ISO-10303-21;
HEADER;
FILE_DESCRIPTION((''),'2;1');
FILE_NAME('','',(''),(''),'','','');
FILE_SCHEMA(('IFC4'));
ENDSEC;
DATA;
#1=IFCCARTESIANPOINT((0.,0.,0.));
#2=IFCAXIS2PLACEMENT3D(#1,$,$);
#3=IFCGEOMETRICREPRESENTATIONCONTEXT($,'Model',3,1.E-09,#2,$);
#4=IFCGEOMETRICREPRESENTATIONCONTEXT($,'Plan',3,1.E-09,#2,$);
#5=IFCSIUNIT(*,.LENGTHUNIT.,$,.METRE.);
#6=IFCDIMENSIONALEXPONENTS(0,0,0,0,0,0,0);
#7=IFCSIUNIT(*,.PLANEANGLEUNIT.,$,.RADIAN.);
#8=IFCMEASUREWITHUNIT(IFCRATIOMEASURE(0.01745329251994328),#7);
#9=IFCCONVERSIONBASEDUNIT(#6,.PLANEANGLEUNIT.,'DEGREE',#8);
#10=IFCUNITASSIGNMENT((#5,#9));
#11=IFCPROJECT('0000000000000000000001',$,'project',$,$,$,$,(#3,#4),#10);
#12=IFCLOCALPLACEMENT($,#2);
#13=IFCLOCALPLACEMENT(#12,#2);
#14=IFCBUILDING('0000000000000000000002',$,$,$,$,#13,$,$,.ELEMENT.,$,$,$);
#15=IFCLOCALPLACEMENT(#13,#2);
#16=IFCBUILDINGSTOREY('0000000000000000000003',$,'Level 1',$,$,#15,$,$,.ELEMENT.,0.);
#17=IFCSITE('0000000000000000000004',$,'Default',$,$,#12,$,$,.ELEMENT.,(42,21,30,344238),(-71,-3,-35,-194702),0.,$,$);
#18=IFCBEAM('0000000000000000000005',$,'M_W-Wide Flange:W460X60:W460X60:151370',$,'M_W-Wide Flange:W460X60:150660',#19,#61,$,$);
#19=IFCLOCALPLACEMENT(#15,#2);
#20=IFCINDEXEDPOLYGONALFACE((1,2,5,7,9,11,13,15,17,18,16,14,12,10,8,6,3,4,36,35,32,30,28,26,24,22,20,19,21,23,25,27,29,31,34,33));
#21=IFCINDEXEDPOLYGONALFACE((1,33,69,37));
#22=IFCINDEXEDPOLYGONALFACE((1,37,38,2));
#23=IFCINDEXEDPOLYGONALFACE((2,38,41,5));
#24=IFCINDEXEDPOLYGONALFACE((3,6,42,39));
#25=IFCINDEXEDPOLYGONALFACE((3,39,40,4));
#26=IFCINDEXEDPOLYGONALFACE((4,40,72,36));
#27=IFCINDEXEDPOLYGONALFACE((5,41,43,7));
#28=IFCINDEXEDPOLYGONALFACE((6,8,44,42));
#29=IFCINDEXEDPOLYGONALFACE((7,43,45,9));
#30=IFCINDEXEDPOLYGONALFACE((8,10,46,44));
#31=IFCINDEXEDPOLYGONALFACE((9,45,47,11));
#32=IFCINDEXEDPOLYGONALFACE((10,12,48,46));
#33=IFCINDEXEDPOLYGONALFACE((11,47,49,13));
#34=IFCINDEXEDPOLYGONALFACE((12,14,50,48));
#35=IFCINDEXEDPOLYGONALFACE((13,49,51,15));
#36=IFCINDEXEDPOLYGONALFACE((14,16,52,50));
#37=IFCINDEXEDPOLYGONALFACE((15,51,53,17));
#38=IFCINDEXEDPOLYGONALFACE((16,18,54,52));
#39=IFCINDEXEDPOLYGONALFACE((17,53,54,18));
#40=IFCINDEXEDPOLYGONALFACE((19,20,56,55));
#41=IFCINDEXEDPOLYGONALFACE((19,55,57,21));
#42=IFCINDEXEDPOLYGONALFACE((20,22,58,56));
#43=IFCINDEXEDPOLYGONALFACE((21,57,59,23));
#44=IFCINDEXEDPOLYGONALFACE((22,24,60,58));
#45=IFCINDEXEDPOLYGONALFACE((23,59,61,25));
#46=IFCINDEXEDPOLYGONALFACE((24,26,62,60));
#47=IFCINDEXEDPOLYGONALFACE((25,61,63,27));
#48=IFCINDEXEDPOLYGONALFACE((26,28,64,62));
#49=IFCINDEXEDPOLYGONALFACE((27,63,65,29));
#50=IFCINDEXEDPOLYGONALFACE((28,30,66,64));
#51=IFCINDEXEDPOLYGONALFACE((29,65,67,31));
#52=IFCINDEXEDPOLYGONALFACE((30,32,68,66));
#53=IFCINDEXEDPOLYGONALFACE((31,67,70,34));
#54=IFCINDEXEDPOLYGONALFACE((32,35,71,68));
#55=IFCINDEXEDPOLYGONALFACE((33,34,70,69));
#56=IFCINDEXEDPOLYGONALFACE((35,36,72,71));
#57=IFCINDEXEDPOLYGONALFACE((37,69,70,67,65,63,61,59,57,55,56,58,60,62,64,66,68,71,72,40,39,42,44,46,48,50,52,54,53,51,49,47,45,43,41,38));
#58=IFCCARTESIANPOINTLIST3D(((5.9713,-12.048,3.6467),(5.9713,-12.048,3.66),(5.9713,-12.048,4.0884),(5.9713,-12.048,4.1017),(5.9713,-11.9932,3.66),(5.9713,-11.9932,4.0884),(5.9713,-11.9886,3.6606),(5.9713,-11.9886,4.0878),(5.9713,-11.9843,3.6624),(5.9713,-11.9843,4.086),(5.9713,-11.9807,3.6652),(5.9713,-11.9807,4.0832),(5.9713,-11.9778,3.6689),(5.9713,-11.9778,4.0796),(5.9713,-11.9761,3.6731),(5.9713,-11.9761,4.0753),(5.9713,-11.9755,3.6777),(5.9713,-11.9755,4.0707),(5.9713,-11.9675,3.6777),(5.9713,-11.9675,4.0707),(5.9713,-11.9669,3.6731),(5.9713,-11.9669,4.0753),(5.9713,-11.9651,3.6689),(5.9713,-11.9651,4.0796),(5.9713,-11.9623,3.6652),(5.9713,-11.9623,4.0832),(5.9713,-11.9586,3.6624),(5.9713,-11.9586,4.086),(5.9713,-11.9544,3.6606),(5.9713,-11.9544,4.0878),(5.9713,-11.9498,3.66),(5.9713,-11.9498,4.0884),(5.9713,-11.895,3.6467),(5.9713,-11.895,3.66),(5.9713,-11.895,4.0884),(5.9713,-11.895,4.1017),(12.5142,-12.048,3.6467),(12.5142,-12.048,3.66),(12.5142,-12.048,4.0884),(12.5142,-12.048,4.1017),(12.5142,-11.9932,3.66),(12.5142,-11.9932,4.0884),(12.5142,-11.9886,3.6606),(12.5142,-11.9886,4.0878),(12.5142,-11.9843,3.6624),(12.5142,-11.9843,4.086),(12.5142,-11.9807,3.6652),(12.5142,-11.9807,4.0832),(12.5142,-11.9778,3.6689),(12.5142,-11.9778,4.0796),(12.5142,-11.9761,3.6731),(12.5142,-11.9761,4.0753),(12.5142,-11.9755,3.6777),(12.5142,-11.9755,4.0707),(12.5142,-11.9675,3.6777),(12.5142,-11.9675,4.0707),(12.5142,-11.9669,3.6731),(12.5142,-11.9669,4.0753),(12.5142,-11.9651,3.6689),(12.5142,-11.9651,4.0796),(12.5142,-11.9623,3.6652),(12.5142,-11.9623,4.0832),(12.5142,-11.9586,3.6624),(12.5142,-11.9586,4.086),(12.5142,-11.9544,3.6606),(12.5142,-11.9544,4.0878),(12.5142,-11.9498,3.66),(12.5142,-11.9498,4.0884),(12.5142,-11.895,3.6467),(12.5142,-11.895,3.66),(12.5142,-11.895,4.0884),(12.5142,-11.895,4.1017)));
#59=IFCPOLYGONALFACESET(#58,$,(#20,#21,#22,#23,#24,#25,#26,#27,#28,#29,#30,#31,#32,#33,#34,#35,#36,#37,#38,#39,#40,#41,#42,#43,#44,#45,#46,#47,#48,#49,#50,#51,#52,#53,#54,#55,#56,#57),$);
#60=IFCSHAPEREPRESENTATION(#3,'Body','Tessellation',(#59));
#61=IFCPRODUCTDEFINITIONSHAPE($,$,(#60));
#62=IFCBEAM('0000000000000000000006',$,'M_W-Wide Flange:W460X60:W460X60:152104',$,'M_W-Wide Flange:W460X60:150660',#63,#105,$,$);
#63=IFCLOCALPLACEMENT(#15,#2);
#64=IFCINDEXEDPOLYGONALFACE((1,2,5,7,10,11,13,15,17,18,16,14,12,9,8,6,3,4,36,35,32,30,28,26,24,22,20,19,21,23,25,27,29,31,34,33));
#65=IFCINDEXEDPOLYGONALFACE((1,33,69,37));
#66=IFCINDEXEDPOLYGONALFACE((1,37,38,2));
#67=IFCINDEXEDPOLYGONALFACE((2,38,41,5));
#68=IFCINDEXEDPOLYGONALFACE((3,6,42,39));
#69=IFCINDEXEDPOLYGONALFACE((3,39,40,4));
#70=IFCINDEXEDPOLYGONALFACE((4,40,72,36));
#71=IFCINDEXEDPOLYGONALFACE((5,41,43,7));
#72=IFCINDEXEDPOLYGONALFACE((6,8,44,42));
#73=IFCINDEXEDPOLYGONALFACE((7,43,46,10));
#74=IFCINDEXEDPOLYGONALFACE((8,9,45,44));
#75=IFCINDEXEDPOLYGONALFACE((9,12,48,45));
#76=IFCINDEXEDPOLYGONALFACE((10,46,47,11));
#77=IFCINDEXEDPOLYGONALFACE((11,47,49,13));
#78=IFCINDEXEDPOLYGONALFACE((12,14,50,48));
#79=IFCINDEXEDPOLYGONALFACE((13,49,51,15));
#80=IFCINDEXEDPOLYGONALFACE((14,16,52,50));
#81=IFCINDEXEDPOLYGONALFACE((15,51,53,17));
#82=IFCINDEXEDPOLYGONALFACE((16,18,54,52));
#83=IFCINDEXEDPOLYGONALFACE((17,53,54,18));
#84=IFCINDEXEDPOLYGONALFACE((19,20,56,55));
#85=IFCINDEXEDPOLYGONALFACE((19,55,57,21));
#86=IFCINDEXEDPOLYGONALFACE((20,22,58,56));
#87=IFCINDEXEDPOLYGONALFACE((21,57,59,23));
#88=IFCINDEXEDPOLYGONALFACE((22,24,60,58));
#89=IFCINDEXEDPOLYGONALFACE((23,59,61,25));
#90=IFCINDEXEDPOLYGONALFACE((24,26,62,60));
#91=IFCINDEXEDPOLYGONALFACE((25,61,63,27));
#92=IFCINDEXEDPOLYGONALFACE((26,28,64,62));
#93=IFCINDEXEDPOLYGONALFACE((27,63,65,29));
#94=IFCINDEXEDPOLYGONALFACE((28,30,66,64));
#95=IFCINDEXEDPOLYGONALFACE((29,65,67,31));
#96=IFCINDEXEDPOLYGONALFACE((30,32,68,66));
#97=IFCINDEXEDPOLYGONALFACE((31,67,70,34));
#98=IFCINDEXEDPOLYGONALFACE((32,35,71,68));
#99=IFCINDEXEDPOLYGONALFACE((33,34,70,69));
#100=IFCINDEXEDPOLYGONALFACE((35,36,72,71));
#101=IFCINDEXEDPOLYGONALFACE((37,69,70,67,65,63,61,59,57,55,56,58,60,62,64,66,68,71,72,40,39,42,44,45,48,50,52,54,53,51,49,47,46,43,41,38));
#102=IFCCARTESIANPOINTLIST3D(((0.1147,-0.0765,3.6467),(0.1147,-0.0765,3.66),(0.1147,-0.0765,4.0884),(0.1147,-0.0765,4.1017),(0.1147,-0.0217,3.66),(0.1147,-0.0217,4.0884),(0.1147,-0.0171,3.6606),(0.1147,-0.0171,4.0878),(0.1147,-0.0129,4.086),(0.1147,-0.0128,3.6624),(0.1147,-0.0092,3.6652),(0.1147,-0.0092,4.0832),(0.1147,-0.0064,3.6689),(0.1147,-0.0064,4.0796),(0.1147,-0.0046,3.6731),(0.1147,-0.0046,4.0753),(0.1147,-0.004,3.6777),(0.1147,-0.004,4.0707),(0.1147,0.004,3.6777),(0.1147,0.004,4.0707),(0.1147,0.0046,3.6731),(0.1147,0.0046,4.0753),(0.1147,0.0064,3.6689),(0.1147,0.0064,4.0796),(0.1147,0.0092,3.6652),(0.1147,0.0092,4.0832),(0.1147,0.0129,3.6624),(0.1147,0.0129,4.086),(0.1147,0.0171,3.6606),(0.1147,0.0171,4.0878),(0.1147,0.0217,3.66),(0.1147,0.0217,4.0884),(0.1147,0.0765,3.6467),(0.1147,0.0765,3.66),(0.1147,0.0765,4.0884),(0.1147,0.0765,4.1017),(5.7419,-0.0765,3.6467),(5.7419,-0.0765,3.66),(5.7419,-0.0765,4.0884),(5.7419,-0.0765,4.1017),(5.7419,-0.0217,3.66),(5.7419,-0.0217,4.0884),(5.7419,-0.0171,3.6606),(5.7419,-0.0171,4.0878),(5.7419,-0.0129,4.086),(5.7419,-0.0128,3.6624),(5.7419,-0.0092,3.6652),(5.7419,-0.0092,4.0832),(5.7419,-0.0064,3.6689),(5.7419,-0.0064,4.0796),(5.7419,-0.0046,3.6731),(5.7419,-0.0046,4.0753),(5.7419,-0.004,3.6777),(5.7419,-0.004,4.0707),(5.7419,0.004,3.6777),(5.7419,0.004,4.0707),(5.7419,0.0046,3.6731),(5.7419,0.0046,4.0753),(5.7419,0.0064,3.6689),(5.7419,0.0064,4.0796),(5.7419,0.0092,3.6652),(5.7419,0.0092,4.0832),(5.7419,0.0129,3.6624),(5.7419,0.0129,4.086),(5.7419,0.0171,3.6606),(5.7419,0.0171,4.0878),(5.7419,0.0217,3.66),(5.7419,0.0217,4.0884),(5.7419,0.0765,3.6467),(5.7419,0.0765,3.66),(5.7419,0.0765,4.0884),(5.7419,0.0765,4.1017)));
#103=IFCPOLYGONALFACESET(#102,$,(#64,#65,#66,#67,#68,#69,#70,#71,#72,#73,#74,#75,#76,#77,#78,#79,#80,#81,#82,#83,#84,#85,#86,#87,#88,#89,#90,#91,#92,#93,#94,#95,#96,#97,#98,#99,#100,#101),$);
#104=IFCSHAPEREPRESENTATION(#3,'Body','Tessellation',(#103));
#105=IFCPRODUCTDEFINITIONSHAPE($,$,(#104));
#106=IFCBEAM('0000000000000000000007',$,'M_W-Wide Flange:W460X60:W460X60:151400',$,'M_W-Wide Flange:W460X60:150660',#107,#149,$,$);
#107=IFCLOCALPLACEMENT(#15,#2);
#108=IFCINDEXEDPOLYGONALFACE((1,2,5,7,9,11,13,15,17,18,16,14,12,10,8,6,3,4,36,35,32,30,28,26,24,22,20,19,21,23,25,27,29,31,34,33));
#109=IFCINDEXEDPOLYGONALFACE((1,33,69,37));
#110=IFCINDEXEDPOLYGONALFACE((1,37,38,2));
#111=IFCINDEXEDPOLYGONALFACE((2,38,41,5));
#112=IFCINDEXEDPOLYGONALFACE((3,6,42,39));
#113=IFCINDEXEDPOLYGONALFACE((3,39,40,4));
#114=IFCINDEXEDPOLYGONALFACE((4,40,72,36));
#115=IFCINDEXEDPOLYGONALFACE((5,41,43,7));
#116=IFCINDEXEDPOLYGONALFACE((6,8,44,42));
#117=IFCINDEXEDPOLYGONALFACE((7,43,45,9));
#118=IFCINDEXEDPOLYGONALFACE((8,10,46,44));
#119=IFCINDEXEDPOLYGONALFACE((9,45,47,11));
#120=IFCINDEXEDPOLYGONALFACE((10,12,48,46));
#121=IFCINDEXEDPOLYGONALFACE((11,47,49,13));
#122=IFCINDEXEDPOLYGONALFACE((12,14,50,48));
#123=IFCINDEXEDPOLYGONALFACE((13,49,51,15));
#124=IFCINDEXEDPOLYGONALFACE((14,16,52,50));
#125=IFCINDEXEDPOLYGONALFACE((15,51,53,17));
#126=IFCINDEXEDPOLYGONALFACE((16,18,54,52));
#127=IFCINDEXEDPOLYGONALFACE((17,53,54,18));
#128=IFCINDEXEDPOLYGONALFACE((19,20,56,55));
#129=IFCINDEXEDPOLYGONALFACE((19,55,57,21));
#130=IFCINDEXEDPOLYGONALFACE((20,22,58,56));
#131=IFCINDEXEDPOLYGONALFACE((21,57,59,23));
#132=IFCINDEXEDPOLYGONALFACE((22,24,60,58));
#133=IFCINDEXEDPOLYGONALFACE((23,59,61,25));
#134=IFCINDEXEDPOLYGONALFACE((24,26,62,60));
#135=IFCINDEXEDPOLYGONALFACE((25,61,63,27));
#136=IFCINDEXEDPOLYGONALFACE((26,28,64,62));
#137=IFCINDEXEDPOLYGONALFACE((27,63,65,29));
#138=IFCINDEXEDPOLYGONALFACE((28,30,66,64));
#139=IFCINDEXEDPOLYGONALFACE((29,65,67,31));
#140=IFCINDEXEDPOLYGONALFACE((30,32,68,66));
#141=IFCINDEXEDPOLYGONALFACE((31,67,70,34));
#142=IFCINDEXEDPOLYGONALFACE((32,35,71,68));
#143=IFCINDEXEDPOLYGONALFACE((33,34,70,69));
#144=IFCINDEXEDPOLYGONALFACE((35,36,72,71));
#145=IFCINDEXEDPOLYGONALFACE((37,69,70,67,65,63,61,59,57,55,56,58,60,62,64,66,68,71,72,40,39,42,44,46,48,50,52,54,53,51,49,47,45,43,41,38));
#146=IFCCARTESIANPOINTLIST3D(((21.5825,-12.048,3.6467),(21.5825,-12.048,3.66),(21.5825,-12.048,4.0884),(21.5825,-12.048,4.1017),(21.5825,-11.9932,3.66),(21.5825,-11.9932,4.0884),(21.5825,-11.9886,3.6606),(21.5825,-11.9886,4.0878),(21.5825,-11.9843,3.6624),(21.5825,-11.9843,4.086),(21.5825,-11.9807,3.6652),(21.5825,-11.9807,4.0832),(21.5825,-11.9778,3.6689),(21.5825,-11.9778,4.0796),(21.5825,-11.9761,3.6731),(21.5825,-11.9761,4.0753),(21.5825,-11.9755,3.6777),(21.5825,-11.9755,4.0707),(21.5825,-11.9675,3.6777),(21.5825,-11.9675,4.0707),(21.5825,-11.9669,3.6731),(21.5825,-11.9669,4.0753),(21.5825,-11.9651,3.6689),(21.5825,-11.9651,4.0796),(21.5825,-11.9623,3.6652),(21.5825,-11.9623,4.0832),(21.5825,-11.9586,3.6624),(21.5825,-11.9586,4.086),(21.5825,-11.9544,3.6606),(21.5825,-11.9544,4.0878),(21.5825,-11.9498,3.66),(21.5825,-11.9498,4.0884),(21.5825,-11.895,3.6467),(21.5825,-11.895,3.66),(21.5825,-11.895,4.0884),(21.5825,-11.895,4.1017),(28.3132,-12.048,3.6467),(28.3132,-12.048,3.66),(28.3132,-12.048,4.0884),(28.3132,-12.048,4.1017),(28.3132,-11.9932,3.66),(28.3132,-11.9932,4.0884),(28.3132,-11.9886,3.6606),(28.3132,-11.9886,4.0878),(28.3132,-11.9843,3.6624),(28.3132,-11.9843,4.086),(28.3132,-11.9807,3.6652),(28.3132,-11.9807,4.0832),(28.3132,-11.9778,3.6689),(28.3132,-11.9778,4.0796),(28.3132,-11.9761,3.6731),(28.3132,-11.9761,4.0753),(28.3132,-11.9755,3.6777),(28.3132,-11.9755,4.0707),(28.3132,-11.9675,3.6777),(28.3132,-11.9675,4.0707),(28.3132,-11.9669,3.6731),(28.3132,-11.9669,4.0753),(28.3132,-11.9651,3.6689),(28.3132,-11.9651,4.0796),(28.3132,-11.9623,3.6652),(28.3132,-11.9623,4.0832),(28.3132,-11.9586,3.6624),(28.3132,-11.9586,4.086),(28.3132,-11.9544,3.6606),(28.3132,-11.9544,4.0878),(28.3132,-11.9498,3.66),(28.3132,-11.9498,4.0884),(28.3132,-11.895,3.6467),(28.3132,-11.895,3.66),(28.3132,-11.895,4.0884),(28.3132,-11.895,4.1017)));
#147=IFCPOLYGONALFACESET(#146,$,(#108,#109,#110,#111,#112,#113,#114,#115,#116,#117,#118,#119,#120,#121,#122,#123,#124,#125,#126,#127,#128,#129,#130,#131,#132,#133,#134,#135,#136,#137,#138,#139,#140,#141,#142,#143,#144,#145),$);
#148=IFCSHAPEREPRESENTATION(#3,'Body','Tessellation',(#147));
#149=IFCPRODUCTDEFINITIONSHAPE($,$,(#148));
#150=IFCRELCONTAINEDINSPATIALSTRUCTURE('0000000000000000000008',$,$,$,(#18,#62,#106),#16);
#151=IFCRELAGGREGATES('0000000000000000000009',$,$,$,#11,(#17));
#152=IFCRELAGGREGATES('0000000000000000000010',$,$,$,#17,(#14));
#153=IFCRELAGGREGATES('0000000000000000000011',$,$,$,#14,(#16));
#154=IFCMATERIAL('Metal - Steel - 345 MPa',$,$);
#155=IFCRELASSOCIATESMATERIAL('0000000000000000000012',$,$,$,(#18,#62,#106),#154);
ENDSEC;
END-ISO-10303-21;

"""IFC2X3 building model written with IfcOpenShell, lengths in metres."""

from ifc_helpers import new_model, entity, si_unit, converted_unit, frame, frame_2d, origin, place, context, project, spatial, polyline, circle_curve, parameter, trimmed, segment, composite_curve, outline, extrude, material, element, save


model = new_model("IFC2X3")

# Units and contexts
model_context = context("Model", 3, precision=1e-09, world=origin())
plan_context = context("Plan", 3, precision=1e-09, world=origin())
ifc_project = project(units=[si_unit("LENGTHUNIT", "METRE"), converted_unit("PLANEANGLEUNIT", "DEGREE", entity("IfcRatioMeasure", 0.01745329251994328), si_unit("PLANEANGLEUNIT", "RADIAN"), dimensions=[0, 0, 0, 0, 0, 0, 0])], contexts=[model_context, plan_context])

# Site, building, storey
site_placement = place(None, origin())
site = spatial("IfcSite", under=ifc_project, at=site_placement, Name="Default", CompositionType="ELEMENT", RefLatitude=(42, 21, 30, 344238), RefLongitude=(-71, -3, -35, -194702), RefElevation=0.0)
building_placement = place(site_placement, origin())
building = spatial("IfcBuilding", under=site, at=building_placement, CompositionType="ELEMENT")
storey_placement = place(building_placement, origin())
storey = spatial("IfcBuildingStorey", under=building, at=storey_placement, Name="Level 1", CompositionType="ELEMENT", Elevation=0.0)

# Beams
ifc_material_1 = material(Name="Metal - Steel - 345 MPa")
beam_1_placement = place(storey_placement, frame((5.8566, -11.9715, 4.2672), z_axis=(0.0, 0.0, 1.0), x_axis=(0.0, -1.0, 0.0)))
element("IfcBeam", 1, at=beam_1_placement, inside=storey, material=ifc_material_1, Name="M_W-Wide Flange:W460X60:W460X60:151370", ObjectType="M_W-Wide Flange:W460X60:150660", context=model_context, shape_type="SweptSolid", body=[
    extrude(outline(composite_curve([segment(polyline([(-0.0765, -0.2142), (-0.0765, -0.2275)]), True, "CONTINUOUS"), segment(polyline([(-0.0765, -0.2275), (0.0765, -0.2275)]), True, "CONTINUOUS"), segment(polyline([(0.0765, -0.2275), (0.0765, -0.2142)]), True, "CONTINUOUS"), segment(polyline([(0.0765, -0.2142), (0.0217, -0.2142)]), True, "CONTINUOUS"), segment(trimmed(circle_curve(frame_2d((0.0217, -0.1965), x_axis=(0.0, -1.0)), 0.0177), [parameter(270.0)], [parameter(360.0)], True, "PARAMETER"), False, "CONTINUOUS"), segment(polyline([(0.004, -0.1965), (0.004, 0.1965)]), True, "CONTINUOUS"), segment(trimmed(circle_curve(frame_2d((0.0217, 0.1965), x_axis=(-1.0, 0.0)), 0.0177), [parameter(270.0)], [parameter(360.0)], True, "PARAMETER"), False, "CONTINUOUS"), segment(polyline([(0.0217, 0.2142), (0.0765, 0.2142)]), True, "CONTINUOUS"), segment(polyline([(0.0765, 0.2142), (0.0765, 0.2275)]), True, "CONTINUOUS"), segment(polyline([(0.0765, 0.2275), (-0.0765, 0.2275)]), True, "CONTINUOUS"), segment(polyline([(-0.0765, 0.2275), (-0.0765, 0.2142)]), True, "CONTINUOUS"), segment(polyline([(-0.0765, 0.2142), (-0.0217, 0.2142)]), True, "CONTINUOUS"), segment(trimmed(circle_curve(frame_2d((-0.0217, 0.1965), x_axis=(0.0, 1.0)), 0.0177), [parameter(270.0)], [parameter(360.0)], True, "PARAMETER"), False, "CONTINUOUS"), segment(polyline([(-0.004, 0.1965), (-0.004, -0.1965)]), True, "CONTINUOUS"), segment(trimmed(circle_curve(frame_2d((-0.0217, -0.1965), x_axis=(1.0, 0.0)), 0.0177), [parameter(270.0)], [parameter(0.0)], True, "PARAMETER"), False, "CONTINUOUS"), segment(polyline([(-0.0217, -0.2142), (-0.0765, -0.2142)]), True, "CONTINUOUS")], self_intersect=False)), frame((0.0, 0.1147, -0.393), z_axis=(0.0, -1.0, 0.0), x_axis=(1.0, 0.0, 0.0)), (0.0, 0.0, -1.0), 6.5429),
])
beam_2_placement = place(storey_placement, frame((0.0, 0.0, 4.2672), z_axis=(0.0, 0.0, 1.0), x_axis=(0.0, -1.0, 0.0)))
element("IfcBeam", 2, at=beam_2_placement, inside=storey, material=ifc_material_1, Name="M_W-Wide Flange:W460X60:W460X60:152104", ObjectType="M_W-Wide Flange:W460X60:150660", context=model_context, shape_type="SweptSolid", body=[
    extrude(outline(composite_curve([segment(polyline([(-0.0765, -0.2142), (-0.0765, -0.2275)]), True, "CONTINUOUS"), segment(polyline([(-0.0765, -0.2275), (0.0765, -0.2275)]), True, "CONTINUOUS"), segment(polyline([(0.0765, -0.2275), (0.0765, -0.2142)]), True, "CONTINUOUS"), segment(polyline([(0.0765, -0.2142), (0.0217, -0.2142)]), True, "CONTINUOUS"), segment(trimmed(circle_curve(frame_2d((0.0217, -0.1965), x_axis=(0.0, -1.0)), 0.0177), [parameter(270.0)], [parameter(360.0)], True, "PARAMETER"), False, "CONTINUOUS"), segment(polyline([(0.004, -0.1965), (0.004, 0.1965)]), True, "CONTINUOUS"), segment(trimmed(circle_curve(frame_2d((0.0217, 0.1965), x_axis=(-1.0, 0.0)), 0.0177), [parameter(270.0)], [parameter(360.0)], True, "PARAMETER"), False, "CONTINUOUS"), segment(polyline([(0.0217, 0.2142), (0.0765, 0.2142)]), True, "CONTINUOUS"), segment(polyline([(0.0765, 0.2142), (0.0765, 0.2275)]), True, "CONTINUOUS"), segment(polyline([(0.0765, 0.2275), (-0.0765, 0.2275)]), True, "CONTINUOUS"), segment(polyline([(-0.0765, 0.2275), (-0.0765, 0.2142)]), True, "CONTINUOUS"), segment(polyline([(-0.0765, 0.2142), (-0.0217, 0.2142)]), True, "CONTINUOUS"), segment(trimmed(circle_curve(frame_2d((-0.0217, 0.1965), x_axis=(0.0, 1.0)), 0.0177), [parameter(270.0)], [parameter(360.0)], True, "PARAMETER"), False, "CONTINUOUS"), segment(polyline([(-0.004, 0.1965), (-0.004, -0.1965)]), True, "CONTINUOUS"), segment(trimmed(circle_curve(frame_2d((-0.0217, -0.1965), x_axis=(1.0, 0.0)), 0.0177), [parameter(270.0)], [parameter(0.0)], True, "PARAMETER"), False, "CONTINUOUS"), segment(polyline([(-0.0217, -0.2142), (-0.0765, -0.2142)]), True, "CONTINUOUS")], self_intersect=False)), frame((0.0, 0.1147, -0.393), z_axis=(0.0, -1.0, 0.0), x_axis=(1.0, 0.0, 0.0)), (0.0, 0.0, -1.0), 5.6272),
])
beam_3_placement = place(storey_placement, frame((21.4678, -11.9715, 4.2672), z_axis=(0.0, 0.0, 1.0), x_axis=(0.0, -1.0, 0.0)))
element("IfcBeam", 3, at=beam_3_placement, inside=storey, material=ifc_material_1, Name="M_W-Wide Flange:W460X60:W460X60:151400", ObjectType="M_W-Wide Flange:W460X60:150660", context=model_context, shape_type="SweptSolid", body=[
    extrude(outline(composite_curve([segment(polyline([(-0.0765, -0.2142), (-0.0765, -0.2275)]), True, "CONTINUOUS"), segment(polyline([(-0.0765, -0.2275), (0.0765, -0.2275)]), True, "CONTINUOUS"), segment(polyline([(0.0765, -0.2275), (0.0765, -0.2142)]), True, "CONTINUOUS"), segment(polyline([(0.0765, -0.2142), (0.0217, -0.2142)]), True, "CONTINUOUS"), segment(trimmed(circle_curve(frame_2d((0.0217, -0.1965), x_axis=(0.0, -1.0)), 0.0177), [parameter(270.0)], [parameter(360.0)], True, "PARAMETER"), False, "CONTINUOUS"), segment(polyline([(0.004, -0.1965), (0.004, 0.1965)]), True, "CONTINUOUS"), segment(trimmed(circle_curve(frame_2d((0.0217, 0.1965), x_axis=(-1.0, 0.0)), 0.0177), [parameter(270.0)], [parameter(360.0)], True, "PARAMETER"), False, "CONTINUOUS"), segment(polyline([(0.0217, 0.2142), (0.0765, 0.2142)]), True, "CONTINUOUS"), segment(polyline([(0.0765, 0.2142), (0.0765, 0.2275)]), True, "CONTINUOUS"), segment(polyline([(0.0765, 0.2275), (-0.0765, 0.2275)]), True, "CONTINUOUS"), segment(polyline([(-0.0765, 0.2275), (-0.0765, 0.2142)]), True, "CONTINUOUS"), segment(polyline([(-0.0765, 0.2142), (-0.0217, 0.2142)]), True, "CONTINUOUS"), segment(trimmed(circle_curve(frame_2d((-0.0217, 0.1965), x_axis=(0.0, 1.0)), 0.0177), [parameter(270.0)], [parameter(360.0)], True, "PARAMETER"), False, "CONTINUOUS"), segment(polyline([(-0.004, 0.1965), (-0.004, -0.1965)]), True, "CONTINUOUS"), segment(trimmed(circle_curve(frame_2d((-0.0217, -0.1965), x_axis=(1.0, 0.0)), 0.0177), [parameter(270.0)], [parameter(0.0)], True, "PARAMETER"), False, "CONTINUOUS"), segment(polyline([(-0.0217, -0.2142), (-0.0765, -0.2142)]), True, "CONTINUOUS")], self_intersect=False)), frame((0.0, 0.1147, -0.393), z_axis=(0.0, -1.0, 0.0), x_axis=(1.0, 0.0, 0.0)), (0.0, 0.0, -1.0), 6.7307),
])

save(model, "model.ifc")
